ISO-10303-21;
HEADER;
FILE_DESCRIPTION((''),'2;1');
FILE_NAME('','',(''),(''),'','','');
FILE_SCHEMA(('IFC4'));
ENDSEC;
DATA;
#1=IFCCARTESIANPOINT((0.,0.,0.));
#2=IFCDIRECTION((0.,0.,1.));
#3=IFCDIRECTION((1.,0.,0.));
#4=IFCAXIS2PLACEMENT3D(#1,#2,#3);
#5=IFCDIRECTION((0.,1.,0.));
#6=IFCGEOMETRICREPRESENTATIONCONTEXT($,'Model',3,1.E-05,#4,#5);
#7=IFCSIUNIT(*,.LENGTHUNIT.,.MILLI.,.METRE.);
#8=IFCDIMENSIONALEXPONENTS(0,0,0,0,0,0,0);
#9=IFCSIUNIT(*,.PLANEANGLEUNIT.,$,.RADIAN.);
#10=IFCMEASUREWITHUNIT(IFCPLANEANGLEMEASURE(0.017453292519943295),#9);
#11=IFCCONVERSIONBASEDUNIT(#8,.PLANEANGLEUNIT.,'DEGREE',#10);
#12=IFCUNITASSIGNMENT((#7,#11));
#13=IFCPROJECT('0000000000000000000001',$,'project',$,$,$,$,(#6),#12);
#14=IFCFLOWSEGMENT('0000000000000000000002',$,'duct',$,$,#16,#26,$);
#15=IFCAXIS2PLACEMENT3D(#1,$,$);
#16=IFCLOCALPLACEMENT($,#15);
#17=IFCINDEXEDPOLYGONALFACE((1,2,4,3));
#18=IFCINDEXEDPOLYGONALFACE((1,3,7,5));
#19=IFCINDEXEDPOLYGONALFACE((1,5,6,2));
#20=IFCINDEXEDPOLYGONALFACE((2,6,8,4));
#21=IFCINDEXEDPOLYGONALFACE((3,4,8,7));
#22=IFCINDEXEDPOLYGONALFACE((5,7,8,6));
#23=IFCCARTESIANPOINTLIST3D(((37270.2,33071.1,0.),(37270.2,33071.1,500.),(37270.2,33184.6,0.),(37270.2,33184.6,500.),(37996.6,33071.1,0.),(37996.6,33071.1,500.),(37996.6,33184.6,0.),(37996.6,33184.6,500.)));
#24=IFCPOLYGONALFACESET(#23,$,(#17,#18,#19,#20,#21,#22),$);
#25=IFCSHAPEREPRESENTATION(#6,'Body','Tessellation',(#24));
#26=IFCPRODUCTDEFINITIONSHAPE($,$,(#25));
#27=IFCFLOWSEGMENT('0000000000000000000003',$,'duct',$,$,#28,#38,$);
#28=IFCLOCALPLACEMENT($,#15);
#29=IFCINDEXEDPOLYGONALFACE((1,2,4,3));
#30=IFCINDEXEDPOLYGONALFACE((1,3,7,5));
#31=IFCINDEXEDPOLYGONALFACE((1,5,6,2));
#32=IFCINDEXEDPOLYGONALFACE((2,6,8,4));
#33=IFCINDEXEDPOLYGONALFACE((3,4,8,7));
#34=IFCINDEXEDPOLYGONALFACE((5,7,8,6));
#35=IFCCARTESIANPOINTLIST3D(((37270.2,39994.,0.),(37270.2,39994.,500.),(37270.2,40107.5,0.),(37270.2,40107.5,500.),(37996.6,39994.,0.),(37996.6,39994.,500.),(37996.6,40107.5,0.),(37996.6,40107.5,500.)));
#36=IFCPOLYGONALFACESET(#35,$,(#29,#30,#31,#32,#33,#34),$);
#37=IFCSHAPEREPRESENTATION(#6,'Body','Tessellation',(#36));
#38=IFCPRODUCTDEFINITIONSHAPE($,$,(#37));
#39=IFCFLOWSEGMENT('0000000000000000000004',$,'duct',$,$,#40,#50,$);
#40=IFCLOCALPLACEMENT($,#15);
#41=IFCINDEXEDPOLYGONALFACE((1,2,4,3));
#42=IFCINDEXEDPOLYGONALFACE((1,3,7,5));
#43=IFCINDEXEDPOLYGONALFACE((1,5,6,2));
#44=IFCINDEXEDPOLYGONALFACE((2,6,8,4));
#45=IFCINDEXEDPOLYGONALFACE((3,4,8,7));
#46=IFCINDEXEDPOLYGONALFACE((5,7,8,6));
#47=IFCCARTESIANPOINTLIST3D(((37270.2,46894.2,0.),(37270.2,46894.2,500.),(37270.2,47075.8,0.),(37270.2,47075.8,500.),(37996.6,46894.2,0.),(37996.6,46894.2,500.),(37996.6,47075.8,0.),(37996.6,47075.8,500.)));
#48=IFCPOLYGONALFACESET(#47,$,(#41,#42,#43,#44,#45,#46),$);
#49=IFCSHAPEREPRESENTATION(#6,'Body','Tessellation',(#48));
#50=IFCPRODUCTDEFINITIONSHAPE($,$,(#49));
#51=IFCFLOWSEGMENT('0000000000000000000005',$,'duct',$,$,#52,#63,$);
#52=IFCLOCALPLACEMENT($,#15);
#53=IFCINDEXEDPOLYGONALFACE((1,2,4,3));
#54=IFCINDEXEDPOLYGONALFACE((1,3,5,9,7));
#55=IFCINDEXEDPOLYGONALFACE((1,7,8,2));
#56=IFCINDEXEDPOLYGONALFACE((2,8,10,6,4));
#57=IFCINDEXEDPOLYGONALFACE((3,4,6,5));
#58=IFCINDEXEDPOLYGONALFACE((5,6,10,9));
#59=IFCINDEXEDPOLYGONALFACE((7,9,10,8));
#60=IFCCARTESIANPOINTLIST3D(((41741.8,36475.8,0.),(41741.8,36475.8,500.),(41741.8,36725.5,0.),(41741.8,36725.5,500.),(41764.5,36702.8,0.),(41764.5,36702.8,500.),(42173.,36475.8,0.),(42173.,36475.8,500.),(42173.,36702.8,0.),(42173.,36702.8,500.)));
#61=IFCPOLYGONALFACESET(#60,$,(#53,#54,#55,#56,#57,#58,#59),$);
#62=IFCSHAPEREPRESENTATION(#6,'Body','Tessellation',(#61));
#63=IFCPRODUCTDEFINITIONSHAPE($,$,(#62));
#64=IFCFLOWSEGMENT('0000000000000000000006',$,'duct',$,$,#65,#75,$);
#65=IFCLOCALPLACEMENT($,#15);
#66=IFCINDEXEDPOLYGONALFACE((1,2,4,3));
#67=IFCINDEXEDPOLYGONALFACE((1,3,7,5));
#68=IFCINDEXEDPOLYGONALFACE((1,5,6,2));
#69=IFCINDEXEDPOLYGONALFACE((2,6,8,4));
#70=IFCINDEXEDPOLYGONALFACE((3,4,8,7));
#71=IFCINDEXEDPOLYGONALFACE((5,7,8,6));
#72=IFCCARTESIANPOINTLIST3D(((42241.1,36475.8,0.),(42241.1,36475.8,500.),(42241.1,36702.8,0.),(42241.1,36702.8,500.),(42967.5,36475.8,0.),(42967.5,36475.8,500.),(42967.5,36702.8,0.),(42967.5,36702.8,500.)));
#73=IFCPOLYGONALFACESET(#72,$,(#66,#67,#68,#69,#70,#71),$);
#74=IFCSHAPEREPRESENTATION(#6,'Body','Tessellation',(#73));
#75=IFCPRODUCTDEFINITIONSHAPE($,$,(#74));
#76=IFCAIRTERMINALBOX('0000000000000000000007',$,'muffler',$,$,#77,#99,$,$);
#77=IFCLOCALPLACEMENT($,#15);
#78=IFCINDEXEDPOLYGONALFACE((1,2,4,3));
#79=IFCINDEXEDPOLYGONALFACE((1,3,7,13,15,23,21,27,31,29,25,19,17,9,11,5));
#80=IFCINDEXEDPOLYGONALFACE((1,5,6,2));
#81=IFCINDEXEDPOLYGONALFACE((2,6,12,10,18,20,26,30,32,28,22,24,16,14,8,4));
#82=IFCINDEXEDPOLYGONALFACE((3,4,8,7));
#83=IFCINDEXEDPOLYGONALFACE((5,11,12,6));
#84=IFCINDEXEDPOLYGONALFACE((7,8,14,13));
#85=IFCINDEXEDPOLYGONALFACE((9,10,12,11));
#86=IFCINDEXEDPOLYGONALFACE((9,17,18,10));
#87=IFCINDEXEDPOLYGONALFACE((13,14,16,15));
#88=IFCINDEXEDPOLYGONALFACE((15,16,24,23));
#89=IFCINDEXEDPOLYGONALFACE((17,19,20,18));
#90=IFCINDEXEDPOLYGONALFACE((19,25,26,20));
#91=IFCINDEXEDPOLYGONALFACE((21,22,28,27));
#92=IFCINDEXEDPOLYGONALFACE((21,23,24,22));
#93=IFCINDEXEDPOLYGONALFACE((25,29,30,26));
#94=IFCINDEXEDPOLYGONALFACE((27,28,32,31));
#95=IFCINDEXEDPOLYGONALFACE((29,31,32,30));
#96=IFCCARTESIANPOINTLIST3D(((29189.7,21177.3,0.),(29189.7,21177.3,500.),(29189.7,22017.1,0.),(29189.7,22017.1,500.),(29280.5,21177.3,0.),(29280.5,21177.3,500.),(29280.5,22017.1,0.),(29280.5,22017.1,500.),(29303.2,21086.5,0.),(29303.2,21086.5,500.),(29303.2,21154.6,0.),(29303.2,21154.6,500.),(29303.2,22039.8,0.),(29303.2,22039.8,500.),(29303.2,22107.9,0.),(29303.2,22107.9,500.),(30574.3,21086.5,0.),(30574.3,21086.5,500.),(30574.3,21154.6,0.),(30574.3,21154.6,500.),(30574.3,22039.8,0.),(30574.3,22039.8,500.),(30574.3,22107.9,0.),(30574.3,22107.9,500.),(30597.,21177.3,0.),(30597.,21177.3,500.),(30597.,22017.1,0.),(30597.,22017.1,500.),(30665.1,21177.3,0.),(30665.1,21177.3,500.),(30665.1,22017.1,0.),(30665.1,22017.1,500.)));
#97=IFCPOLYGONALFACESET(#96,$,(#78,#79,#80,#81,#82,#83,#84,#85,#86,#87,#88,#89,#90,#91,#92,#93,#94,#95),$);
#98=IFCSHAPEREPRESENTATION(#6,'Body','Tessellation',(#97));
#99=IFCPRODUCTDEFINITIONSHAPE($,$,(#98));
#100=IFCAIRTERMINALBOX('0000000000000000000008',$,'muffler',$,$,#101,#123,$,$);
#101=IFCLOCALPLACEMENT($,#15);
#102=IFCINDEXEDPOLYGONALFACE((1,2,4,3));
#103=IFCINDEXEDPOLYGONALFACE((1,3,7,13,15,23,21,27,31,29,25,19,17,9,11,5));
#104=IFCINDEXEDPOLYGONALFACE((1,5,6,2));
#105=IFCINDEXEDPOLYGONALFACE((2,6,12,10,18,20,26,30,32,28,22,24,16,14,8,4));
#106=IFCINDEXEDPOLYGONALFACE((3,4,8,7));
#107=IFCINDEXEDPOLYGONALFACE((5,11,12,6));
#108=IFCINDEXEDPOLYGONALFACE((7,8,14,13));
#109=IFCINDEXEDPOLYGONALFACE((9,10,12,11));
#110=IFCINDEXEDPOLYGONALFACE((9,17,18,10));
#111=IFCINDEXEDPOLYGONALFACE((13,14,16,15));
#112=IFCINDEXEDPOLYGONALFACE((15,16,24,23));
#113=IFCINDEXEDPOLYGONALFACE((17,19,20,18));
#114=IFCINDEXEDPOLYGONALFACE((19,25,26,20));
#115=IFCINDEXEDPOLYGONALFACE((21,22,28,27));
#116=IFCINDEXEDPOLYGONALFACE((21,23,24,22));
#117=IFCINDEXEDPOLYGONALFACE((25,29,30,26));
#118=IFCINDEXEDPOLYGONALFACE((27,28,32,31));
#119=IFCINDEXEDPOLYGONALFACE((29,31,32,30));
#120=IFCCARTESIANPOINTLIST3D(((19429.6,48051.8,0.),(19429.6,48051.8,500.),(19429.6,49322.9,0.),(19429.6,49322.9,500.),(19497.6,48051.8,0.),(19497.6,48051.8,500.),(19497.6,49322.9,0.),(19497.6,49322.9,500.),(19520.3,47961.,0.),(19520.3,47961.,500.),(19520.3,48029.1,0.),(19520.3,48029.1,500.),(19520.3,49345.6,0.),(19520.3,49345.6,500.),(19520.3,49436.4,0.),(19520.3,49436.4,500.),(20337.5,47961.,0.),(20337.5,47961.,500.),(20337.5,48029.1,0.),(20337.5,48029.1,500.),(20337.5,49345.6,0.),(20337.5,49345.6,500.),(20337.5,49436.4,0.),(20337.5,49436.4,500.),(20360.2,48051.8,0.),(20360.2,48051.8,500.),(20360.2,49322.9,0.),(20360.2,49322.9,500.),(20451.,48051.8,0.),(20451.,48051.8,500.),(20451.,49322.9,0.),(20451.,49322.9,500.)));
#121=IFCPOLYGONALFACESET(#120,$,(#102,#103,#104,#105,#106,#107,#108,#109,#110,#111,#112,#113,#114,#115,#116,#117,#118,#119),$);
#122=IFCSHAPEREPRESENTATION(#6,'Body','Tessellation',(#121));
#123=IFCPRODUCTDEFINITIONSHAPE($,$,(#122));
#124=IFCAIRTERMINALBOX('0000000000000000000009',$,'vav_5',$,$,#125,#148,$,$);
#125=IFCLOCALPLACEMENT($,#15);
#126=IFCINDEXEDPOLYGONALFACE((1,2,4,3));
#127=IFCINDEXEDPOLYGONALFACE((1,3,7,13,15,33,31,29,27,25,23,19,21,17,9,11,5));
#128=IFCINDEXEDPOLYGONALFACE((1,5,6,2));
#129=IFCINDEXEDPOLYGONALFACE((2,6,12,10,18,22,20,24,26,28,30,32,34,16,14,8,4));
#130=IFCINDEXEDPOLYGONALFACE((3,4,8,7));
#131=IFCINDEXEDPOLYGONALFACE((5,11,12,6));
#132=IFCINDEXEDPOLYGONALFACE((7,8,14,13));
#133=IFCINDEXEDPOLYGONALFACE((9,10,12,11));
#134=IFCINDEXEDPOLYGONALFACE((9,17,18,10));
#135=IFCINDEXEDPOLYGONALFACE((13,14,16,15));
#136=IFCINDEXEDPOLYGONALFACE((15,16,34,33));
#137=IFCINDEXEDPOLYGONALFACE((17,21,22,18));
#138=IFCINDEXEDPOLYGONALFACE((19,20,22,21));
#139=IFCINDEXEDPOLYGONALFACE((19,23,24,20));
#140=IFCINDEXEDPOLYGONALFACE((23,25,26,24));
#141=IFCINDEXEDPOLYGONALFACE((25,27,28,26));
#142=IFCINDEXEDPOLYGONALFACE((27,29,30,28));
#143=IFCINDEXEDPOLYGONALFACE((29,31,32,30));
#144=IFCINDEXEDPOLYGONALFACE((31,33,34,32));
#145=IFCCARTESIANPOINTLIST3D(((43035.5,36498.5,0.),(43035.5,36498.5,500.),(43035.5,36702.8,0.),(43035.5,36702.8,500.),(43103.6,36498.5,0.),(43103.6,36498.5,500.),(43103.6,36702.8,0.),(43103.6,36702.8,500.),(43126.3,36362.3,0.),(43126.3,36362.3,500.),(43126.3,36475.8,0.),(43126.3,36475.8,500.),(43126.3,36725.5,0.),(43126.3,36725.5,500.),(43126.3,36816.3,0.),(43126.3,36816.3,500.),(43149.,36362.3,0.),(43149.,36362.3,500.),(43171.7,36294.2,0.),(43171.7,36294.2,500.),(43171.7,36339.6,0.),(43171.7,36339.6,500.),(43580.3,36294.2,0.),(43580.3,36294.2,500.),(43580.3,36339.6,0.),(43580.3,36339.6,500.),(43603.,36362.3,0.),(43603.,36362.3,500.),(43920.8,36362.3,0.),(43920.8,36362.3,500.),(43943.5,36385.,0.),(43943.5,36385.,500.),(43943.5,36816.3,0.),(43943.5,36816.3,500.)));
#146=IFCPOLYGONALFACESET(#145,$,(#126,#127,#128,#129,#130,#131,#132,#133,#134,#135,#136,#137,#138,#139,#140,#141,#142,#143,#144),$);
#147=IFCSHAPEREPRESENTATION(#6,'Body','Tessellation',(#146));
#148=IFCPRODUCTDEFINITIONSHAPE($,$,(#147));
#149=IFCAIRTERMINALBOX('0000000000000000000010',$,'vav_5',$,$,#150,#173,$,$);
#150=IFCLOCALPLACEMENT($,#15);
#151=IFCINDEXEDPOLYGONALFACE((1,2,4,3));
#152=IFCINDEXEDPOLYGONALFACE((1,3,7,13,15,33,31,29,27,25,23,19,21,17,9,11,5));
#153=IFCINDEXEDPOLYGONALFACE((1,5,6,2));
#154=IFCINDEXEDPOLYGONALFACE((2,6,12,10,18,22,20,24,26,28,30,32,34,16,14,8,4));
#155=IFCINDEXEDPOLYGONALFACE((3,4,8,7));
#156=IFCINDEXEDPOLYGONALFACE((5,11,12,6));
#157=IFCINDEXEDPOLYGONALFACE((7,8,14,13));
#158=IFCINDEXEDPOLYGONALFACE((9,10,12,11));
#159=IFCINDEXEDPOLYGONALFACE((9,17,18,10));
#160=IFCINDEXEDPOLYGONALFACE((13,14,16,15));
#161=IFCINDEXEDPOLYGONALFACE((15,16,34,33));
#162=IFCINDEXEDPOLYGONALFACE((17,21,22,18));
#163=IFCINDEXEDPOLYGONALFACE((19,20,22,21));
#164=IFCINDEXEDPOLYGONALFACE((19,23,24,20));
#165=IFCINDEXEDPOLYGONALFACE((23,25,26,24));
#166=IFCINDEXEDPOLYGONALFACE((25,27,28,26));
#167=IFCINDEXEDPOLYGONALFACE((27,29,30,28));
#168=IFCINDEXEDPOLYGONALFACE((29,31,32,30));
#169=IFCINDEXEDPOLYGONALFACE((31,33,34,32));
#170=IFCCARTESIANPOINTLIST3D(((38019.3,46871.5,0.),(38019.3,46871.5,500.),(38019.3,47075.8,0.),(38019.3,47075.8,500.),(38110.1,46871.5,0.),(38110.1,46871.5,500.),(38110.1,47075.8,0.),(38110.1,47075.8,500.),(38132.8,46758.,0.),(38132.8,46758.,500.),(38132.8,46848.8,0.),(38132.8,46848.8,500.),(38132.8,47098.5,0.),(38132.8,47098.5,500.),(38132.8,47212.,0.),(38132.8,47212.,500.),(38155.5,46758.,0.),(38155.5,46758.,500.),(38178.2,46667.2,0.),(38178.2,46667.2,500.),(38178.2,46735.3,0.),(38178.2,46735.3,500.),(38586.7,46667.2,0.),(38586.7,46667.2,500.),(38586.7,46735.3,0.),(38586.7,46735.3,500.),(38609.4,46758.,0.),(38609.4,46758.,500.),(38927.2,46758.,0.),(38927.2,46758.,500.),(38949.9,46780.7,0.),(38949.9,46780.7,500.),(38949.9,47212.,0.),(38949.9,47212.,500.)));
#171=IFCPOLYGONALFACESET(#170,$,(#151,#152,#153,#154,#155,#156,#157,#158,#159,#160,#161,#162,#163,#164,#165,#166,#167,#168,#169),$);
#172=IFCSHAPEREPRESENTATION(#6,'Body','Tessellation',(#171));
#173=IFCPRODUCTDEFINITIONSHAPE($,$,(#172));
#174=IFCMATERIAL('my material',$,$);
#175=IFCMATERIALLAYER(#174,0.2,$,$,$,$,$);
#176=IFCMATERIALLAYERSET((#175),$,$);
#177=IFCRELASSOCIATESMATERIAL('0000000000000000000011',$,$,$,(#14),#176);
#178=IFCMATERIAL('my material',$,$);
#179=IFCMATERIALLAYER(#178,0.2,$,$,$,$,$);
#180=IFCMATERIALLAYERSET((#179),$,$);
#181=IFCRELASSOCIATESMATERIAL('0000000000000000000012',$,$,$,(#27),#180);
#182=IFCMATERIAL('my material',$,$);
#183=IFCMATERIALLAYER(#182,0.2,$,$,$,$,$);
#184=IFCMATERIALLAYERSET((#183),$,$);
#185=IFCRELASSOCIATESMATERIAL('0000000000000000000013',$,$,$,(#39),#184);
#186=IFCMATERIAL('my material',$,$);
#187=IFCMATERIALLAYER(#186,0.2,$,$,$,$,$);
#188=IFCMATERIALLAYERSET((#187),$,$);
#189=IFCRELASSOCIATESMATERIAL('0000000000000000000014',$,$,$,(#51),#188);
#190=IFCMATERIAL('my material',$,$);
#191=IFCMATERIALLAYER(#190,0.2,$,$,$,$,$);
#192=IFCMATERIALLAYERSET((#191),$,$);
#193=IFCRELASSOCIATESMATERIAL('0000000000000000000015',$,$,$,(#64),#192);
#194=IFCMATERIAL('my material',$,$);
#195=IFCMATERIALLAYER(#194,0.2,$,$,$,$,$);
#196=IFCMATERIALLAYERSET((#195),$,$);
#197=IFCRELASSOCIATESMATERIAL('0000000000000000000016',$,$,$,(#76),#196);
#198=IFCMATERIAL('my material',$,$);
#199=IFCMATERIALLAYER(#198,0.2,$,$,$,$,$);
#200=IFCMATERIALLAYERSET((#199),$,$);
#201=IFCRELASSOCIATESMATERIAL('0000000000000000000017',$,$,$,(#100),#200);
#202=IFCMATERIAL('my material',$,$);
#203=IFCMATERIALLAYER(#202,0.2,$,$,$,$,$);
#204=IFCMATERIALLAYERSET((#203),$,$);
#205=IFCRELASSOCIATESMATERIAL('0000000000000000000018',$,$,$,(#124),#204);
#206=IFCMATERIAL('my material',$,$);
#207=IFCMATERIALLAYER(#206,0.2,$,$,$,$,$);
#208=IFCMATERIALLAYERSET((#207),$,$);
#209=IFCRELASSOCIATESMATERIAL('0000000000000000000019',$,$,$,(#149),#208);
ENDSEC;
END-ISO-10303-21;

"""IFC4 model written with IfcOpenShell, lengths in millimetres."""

from ifc_helpers import new_model, entity, si_unit, converted_unit, direction, origin_with_axes, place, context, project, polyline, outline, extrude, material, layer, layer_set, layer_usage, element, save


model = new_model("IFC4")

# Units and contexts
model_context = context("Model", 3, precision=1e-05, world=origin_with_axes(), true_north=direction((0.0, 1.0, 0.0)))
ifc_project = project(units=[si_unit("LENGTHUNIT", "METRE", prefix="MILLI"), converted_unit("PLANEANGLEUNIT", "DEGREE", entity("IfcPlaneAngleMeasure", 0.017453292519943295), si_unit("PLANEANGLEUNIT", "RADIAN"), dimensions=[0, 0, 0, 0, 0, 0, 0])], contexts=[model_context])

# Flow segments
ifc_material_1 = material(Name="my material")
ifc_layer_1 = layer(ifc_material_1, 0.2)
ifc_layer_set_1 = layer_set([ifc_layer_1])
ifc_layer_usage_1 = layer_usage(ifc_layer_set_1, "AXIS2", "POSITIVE", -0.1)
flow_segment_1_placement = place(None, origin_with_axes())
element("IfcFlowSegment", 1, at=flow_segment_1_placement, material=ifc_layer_usage_1, Name="duct", context=model_context, shape_type="SweptSolid", body=[
    extrude(outline(polyline([(37270.2, 33071.1), (37996.6, 33071.1), (37996.6, 33184.6), (37270.2, 33184.6), (37270.2, 33071.1)])), origin_with_axes(), (0.0, 0.0, 1.0), 500.0),
])
ifc_material_2 = material(Name="my material")
ifc_layer_2 = layer(ifc_material_2, 0.2)
ifc_layer_set_2 = layer_set([ifc_layer_2])
ifc_layer_usage_2 = layer_usage(ifc_layer_set_2, "AXIS2", "POSITIVE", -0.1)
flow_segment_2_placement = place(None, origin_with_axes())
element("IfcFlowSegment", 2, at=flow_segment_2_placement, material=ifc_layer_usage_2, Name="duct", context=model_context, shape_type="SweptSolid", body=[
    extrude(outline(polyline([(37270.2, 39994.0), (37996.6, 39994.0), (37996.6, 40107.5), (37270.2, 40107.5), (37270.2, 39994.0)])), origin_with_axes(), (0.0, 0.0, 1.0), 500.0),
])
ifc_material_3 = material(Name="my material")
ifc_layer_3 = layer(ifc_material_3, 0.2)
ifc_layer_set_3 = layer_set([ifc_layer_3])
ifc_layer_usage_3 = layer_usage(ifc_layer_set_3, "AXIS2", "POSITIVE", -0.1)
flow_segment_3_placement = place(None, origin_with_axes())
element("IfcFlowSegment", 3, at=flow_segment_3_placement, material=ifc_layer_usage_3, Name="duct", context=model_context, shape_type="SweptSolid", body=[
    extrude(outline(polyline([(37270.2, 46894.2), (37996.6, 46894.2), (37996.6, 47075.8), (37270.2, 47075.8), (37270.2, 46894.2)])), origin_with_axes(), (0.0, 0.0, 1.0), 500.0),
])
ifc_material_4 = material(Name="my material")
ifc_layer_4 = layer(ifc_material_4, 0.2)
ifc_layer_set_4 = layer_set([ifc_layer_4])
ifc_layer_usage_4 = layer_usage(ifc_layer_set_4, "AXIS2", "POSITIVE", -0.1)
flow_segment_4_placement = place(None, origin_with_axes())
element("IfcFlowSegment", 4, at=flow_segment_4_placement, material=ifc_layer_usage_4, Name="duct", context=model_context, shape_type="SweptSolid", body=[
    extrude(outline(polyline([(41741.8, 36475.8), (42173.0, 36475.8), (42173.0, 36702.8), (41764.5, 36702.8), (41741.8, 36725.5), (41741.8, 36475.8)])), origin_with_axes(), (0.0, 0.0, 1.0), 500.0),
])
ifc_material_5 = material(Name="my material")
ifc_layer_5 = layer(ifc_material_5, 0.2)
ifc_layer_set_5 = layer_set([ifc_layer_5])
ifc_layer_usage_5 = layer_usage(ifc_layer_set_5, "AXIS2", "POSITIVE", -0.1)
flow_segment_5_placement = place(None, origin_with_axes())
element("IfcFlowSegment", 5, at=flow_segment_5_placement, material=ifc_layer_usage_5, Name="duct", context=model_context, shape_type="SweptSolid", body=[
    extrude(outline(polyline([(42241.1, 36475.8), (42967.5, 36475.8), (42967.5, 36702.8), (42241.1, 36702.8), (42241.1, 36475.8)])), origin_with_axes(), (0.0, 0.0, 1.0), 500.0),
])

# Air terminal boxes
ifc_material_6 = material(Name="my material")
ifc_layer_6 = layer(ifc_material_6, 0.2)
ifc_layer_set_6 = layer_set([ifc_layer_6])
ifc_layer_usage_6 = layer_usage(ifc_layer_set_6, "AXIS2", "POSITIVE", -0.1)
air_terminal_box_1_placement = place(None, origin_with_axes())
element("IfcAirTerminalBox", 6, at=air_terminal_box_1_placement, material=ifc_layer_usage_6, Name="muffler", context=model_context, shape_type="SweptSolid", body=[
    extrude(outline(polyline([(29189.7, 21177.3), (29280.5, 21177.3), (29303.2, 21154.6), (29303.2, 21086.5), (30574.3, 21086.5), (30574.3, 21154.6), (30597.0, 21177.3), (30665.1, 21177.3), (30665.1, 22017.1), (30597.0, 22017.1), (30574.3, 22039.8), (30574.3, 22107.9), (29303.2, 22107.9), (29303.2, 22039.8), (29280.5, 22017.1), (29189.7, 22017.1), (29189.7, 21177.3)])), origin_with_axes(), (0.0, 0.0, 1.0), 500.0),
])
ifc_material_7 = material(Name="my material")
ifc_layer_7 = layer(ifc_material_7, 0.2)
ifc_layer_set_7 = layer_set([ifc_layer_7])
ifc_layer_usage_7 = layer_usage(ifc_layer_set_7, "AXIS2", "POSITIVE", -0.1)
air_terminal_box_2_placement = place(None, origin_with_axes())
element("IfcAirTerminalBox", 7, at=air_terminal_box_2_placement, material=ifc_layer_usage_7, Name="muffler", context=model_context, shape_type="SweptSolid", body=[
    extrude(outline(polyline([(19429.6, 48051.8), (19497.6, 48051.8), (19520.3, 48029.1), (19520.3, 47961.0), (20337.5, 47961.0), (20337.5, 48029.1), (20360.2, 48051.8), (20451.0, 48051.8), (20451.0, 49322.9), (20360.2, 49322.9), (20337.5, 49345.6), (20337.5, 49436.4), (19520.3, 49436.4), (19520.3, 49345.6), (19497.6, 49322.9), (19429.6, 49322.9), (19429.6, 48051.8)])), origin_with_axes(), (0.0, 0.0, 1.0), 500.0),
])
ifc_material_8 = material(Name="my material")
ifc_layer_8 = layer(ifc_material_8, 0.2)
ifc_layer_set_8 = layer_set([ifc_layer_8])
ifc_layer_usage_8 = layer_usage(ifc_layer_set_8, "AXIS2", "POSITIVE", -0.1)
air_terminal_box_3_placement = place(None, origin_with_axes())
element("IfcAirTerminalBox", 8, at=air_terminal_box_3_placement, material=ifc_layer_usage_8, Name="vav_5", context=model_context, shape_type="SweptSolid", body=[
    extrude(outline(polyline([(43035.5, 36498.5), (43103.6, 36498.5), (43126.3, 36475.8), (43126.3, 36362.3), (43149.0, 36362.3), (43171.7, 36339.6), (43171.7, 36294.2), (43580.3, 36294.2), (43580.3, 36339.6), (43603.0, 36362.3), (43920.8, 36362.3), (43943.5, 36385.0), (43943.5, 36816.3), (43126.3, 36816.3), (43126.3, 36725.5), (43103.6, 36702.8), (43035.5, 36702.8), (43035.5, 36498.5)])), origin_with_axes(), (0.0, 0.0, 1.0), 500.0),
])
ifc_material_9 = material(Name="my material")
ifc_layer_9 = layer(ifc_material_9, 0.2)
ifc_layer_set_9 = layer_set([ifc_layer_9])
ifc_layer_usage_9 = layer_usage(ifc_layer_set_9, "AXIS2", "POSITIVE", -0.1)
air_terminal_box_4_placement = place(None, origin_with_axes())
element("IfcAirTerminalBox", 9, at=air_terminal_box_4_placement, material=ifc_layer_usage_9, Name="vav_5", context=model_context, shape_type="SweptSolid", body=[
    extrude(outline(polyline([(38019.3, 46871.5), (38110.1, 46871.5), (38132.8, 46848.8), (38132.8, 46758.0), (38155.5, 46758.0), (38178.2, 46735.3), (38178.2, 46667.2), (38586.7, 46667.2), (38586.7, 46735.3), (38609.4, 46758.0), (38927.2, 46758.0), (38949.9, 46780.7), (38949.9, 47212.0), (38132.8, 47212.0), (38132.8, 47098.5), (38110.1, 47075.8), (38019.3, 47075.8), (38019.3, 46871.5)])), origin_with_axes(), (0.0, 0.0, 1.0), 500.0),
])

save(model, "model.ifc")
